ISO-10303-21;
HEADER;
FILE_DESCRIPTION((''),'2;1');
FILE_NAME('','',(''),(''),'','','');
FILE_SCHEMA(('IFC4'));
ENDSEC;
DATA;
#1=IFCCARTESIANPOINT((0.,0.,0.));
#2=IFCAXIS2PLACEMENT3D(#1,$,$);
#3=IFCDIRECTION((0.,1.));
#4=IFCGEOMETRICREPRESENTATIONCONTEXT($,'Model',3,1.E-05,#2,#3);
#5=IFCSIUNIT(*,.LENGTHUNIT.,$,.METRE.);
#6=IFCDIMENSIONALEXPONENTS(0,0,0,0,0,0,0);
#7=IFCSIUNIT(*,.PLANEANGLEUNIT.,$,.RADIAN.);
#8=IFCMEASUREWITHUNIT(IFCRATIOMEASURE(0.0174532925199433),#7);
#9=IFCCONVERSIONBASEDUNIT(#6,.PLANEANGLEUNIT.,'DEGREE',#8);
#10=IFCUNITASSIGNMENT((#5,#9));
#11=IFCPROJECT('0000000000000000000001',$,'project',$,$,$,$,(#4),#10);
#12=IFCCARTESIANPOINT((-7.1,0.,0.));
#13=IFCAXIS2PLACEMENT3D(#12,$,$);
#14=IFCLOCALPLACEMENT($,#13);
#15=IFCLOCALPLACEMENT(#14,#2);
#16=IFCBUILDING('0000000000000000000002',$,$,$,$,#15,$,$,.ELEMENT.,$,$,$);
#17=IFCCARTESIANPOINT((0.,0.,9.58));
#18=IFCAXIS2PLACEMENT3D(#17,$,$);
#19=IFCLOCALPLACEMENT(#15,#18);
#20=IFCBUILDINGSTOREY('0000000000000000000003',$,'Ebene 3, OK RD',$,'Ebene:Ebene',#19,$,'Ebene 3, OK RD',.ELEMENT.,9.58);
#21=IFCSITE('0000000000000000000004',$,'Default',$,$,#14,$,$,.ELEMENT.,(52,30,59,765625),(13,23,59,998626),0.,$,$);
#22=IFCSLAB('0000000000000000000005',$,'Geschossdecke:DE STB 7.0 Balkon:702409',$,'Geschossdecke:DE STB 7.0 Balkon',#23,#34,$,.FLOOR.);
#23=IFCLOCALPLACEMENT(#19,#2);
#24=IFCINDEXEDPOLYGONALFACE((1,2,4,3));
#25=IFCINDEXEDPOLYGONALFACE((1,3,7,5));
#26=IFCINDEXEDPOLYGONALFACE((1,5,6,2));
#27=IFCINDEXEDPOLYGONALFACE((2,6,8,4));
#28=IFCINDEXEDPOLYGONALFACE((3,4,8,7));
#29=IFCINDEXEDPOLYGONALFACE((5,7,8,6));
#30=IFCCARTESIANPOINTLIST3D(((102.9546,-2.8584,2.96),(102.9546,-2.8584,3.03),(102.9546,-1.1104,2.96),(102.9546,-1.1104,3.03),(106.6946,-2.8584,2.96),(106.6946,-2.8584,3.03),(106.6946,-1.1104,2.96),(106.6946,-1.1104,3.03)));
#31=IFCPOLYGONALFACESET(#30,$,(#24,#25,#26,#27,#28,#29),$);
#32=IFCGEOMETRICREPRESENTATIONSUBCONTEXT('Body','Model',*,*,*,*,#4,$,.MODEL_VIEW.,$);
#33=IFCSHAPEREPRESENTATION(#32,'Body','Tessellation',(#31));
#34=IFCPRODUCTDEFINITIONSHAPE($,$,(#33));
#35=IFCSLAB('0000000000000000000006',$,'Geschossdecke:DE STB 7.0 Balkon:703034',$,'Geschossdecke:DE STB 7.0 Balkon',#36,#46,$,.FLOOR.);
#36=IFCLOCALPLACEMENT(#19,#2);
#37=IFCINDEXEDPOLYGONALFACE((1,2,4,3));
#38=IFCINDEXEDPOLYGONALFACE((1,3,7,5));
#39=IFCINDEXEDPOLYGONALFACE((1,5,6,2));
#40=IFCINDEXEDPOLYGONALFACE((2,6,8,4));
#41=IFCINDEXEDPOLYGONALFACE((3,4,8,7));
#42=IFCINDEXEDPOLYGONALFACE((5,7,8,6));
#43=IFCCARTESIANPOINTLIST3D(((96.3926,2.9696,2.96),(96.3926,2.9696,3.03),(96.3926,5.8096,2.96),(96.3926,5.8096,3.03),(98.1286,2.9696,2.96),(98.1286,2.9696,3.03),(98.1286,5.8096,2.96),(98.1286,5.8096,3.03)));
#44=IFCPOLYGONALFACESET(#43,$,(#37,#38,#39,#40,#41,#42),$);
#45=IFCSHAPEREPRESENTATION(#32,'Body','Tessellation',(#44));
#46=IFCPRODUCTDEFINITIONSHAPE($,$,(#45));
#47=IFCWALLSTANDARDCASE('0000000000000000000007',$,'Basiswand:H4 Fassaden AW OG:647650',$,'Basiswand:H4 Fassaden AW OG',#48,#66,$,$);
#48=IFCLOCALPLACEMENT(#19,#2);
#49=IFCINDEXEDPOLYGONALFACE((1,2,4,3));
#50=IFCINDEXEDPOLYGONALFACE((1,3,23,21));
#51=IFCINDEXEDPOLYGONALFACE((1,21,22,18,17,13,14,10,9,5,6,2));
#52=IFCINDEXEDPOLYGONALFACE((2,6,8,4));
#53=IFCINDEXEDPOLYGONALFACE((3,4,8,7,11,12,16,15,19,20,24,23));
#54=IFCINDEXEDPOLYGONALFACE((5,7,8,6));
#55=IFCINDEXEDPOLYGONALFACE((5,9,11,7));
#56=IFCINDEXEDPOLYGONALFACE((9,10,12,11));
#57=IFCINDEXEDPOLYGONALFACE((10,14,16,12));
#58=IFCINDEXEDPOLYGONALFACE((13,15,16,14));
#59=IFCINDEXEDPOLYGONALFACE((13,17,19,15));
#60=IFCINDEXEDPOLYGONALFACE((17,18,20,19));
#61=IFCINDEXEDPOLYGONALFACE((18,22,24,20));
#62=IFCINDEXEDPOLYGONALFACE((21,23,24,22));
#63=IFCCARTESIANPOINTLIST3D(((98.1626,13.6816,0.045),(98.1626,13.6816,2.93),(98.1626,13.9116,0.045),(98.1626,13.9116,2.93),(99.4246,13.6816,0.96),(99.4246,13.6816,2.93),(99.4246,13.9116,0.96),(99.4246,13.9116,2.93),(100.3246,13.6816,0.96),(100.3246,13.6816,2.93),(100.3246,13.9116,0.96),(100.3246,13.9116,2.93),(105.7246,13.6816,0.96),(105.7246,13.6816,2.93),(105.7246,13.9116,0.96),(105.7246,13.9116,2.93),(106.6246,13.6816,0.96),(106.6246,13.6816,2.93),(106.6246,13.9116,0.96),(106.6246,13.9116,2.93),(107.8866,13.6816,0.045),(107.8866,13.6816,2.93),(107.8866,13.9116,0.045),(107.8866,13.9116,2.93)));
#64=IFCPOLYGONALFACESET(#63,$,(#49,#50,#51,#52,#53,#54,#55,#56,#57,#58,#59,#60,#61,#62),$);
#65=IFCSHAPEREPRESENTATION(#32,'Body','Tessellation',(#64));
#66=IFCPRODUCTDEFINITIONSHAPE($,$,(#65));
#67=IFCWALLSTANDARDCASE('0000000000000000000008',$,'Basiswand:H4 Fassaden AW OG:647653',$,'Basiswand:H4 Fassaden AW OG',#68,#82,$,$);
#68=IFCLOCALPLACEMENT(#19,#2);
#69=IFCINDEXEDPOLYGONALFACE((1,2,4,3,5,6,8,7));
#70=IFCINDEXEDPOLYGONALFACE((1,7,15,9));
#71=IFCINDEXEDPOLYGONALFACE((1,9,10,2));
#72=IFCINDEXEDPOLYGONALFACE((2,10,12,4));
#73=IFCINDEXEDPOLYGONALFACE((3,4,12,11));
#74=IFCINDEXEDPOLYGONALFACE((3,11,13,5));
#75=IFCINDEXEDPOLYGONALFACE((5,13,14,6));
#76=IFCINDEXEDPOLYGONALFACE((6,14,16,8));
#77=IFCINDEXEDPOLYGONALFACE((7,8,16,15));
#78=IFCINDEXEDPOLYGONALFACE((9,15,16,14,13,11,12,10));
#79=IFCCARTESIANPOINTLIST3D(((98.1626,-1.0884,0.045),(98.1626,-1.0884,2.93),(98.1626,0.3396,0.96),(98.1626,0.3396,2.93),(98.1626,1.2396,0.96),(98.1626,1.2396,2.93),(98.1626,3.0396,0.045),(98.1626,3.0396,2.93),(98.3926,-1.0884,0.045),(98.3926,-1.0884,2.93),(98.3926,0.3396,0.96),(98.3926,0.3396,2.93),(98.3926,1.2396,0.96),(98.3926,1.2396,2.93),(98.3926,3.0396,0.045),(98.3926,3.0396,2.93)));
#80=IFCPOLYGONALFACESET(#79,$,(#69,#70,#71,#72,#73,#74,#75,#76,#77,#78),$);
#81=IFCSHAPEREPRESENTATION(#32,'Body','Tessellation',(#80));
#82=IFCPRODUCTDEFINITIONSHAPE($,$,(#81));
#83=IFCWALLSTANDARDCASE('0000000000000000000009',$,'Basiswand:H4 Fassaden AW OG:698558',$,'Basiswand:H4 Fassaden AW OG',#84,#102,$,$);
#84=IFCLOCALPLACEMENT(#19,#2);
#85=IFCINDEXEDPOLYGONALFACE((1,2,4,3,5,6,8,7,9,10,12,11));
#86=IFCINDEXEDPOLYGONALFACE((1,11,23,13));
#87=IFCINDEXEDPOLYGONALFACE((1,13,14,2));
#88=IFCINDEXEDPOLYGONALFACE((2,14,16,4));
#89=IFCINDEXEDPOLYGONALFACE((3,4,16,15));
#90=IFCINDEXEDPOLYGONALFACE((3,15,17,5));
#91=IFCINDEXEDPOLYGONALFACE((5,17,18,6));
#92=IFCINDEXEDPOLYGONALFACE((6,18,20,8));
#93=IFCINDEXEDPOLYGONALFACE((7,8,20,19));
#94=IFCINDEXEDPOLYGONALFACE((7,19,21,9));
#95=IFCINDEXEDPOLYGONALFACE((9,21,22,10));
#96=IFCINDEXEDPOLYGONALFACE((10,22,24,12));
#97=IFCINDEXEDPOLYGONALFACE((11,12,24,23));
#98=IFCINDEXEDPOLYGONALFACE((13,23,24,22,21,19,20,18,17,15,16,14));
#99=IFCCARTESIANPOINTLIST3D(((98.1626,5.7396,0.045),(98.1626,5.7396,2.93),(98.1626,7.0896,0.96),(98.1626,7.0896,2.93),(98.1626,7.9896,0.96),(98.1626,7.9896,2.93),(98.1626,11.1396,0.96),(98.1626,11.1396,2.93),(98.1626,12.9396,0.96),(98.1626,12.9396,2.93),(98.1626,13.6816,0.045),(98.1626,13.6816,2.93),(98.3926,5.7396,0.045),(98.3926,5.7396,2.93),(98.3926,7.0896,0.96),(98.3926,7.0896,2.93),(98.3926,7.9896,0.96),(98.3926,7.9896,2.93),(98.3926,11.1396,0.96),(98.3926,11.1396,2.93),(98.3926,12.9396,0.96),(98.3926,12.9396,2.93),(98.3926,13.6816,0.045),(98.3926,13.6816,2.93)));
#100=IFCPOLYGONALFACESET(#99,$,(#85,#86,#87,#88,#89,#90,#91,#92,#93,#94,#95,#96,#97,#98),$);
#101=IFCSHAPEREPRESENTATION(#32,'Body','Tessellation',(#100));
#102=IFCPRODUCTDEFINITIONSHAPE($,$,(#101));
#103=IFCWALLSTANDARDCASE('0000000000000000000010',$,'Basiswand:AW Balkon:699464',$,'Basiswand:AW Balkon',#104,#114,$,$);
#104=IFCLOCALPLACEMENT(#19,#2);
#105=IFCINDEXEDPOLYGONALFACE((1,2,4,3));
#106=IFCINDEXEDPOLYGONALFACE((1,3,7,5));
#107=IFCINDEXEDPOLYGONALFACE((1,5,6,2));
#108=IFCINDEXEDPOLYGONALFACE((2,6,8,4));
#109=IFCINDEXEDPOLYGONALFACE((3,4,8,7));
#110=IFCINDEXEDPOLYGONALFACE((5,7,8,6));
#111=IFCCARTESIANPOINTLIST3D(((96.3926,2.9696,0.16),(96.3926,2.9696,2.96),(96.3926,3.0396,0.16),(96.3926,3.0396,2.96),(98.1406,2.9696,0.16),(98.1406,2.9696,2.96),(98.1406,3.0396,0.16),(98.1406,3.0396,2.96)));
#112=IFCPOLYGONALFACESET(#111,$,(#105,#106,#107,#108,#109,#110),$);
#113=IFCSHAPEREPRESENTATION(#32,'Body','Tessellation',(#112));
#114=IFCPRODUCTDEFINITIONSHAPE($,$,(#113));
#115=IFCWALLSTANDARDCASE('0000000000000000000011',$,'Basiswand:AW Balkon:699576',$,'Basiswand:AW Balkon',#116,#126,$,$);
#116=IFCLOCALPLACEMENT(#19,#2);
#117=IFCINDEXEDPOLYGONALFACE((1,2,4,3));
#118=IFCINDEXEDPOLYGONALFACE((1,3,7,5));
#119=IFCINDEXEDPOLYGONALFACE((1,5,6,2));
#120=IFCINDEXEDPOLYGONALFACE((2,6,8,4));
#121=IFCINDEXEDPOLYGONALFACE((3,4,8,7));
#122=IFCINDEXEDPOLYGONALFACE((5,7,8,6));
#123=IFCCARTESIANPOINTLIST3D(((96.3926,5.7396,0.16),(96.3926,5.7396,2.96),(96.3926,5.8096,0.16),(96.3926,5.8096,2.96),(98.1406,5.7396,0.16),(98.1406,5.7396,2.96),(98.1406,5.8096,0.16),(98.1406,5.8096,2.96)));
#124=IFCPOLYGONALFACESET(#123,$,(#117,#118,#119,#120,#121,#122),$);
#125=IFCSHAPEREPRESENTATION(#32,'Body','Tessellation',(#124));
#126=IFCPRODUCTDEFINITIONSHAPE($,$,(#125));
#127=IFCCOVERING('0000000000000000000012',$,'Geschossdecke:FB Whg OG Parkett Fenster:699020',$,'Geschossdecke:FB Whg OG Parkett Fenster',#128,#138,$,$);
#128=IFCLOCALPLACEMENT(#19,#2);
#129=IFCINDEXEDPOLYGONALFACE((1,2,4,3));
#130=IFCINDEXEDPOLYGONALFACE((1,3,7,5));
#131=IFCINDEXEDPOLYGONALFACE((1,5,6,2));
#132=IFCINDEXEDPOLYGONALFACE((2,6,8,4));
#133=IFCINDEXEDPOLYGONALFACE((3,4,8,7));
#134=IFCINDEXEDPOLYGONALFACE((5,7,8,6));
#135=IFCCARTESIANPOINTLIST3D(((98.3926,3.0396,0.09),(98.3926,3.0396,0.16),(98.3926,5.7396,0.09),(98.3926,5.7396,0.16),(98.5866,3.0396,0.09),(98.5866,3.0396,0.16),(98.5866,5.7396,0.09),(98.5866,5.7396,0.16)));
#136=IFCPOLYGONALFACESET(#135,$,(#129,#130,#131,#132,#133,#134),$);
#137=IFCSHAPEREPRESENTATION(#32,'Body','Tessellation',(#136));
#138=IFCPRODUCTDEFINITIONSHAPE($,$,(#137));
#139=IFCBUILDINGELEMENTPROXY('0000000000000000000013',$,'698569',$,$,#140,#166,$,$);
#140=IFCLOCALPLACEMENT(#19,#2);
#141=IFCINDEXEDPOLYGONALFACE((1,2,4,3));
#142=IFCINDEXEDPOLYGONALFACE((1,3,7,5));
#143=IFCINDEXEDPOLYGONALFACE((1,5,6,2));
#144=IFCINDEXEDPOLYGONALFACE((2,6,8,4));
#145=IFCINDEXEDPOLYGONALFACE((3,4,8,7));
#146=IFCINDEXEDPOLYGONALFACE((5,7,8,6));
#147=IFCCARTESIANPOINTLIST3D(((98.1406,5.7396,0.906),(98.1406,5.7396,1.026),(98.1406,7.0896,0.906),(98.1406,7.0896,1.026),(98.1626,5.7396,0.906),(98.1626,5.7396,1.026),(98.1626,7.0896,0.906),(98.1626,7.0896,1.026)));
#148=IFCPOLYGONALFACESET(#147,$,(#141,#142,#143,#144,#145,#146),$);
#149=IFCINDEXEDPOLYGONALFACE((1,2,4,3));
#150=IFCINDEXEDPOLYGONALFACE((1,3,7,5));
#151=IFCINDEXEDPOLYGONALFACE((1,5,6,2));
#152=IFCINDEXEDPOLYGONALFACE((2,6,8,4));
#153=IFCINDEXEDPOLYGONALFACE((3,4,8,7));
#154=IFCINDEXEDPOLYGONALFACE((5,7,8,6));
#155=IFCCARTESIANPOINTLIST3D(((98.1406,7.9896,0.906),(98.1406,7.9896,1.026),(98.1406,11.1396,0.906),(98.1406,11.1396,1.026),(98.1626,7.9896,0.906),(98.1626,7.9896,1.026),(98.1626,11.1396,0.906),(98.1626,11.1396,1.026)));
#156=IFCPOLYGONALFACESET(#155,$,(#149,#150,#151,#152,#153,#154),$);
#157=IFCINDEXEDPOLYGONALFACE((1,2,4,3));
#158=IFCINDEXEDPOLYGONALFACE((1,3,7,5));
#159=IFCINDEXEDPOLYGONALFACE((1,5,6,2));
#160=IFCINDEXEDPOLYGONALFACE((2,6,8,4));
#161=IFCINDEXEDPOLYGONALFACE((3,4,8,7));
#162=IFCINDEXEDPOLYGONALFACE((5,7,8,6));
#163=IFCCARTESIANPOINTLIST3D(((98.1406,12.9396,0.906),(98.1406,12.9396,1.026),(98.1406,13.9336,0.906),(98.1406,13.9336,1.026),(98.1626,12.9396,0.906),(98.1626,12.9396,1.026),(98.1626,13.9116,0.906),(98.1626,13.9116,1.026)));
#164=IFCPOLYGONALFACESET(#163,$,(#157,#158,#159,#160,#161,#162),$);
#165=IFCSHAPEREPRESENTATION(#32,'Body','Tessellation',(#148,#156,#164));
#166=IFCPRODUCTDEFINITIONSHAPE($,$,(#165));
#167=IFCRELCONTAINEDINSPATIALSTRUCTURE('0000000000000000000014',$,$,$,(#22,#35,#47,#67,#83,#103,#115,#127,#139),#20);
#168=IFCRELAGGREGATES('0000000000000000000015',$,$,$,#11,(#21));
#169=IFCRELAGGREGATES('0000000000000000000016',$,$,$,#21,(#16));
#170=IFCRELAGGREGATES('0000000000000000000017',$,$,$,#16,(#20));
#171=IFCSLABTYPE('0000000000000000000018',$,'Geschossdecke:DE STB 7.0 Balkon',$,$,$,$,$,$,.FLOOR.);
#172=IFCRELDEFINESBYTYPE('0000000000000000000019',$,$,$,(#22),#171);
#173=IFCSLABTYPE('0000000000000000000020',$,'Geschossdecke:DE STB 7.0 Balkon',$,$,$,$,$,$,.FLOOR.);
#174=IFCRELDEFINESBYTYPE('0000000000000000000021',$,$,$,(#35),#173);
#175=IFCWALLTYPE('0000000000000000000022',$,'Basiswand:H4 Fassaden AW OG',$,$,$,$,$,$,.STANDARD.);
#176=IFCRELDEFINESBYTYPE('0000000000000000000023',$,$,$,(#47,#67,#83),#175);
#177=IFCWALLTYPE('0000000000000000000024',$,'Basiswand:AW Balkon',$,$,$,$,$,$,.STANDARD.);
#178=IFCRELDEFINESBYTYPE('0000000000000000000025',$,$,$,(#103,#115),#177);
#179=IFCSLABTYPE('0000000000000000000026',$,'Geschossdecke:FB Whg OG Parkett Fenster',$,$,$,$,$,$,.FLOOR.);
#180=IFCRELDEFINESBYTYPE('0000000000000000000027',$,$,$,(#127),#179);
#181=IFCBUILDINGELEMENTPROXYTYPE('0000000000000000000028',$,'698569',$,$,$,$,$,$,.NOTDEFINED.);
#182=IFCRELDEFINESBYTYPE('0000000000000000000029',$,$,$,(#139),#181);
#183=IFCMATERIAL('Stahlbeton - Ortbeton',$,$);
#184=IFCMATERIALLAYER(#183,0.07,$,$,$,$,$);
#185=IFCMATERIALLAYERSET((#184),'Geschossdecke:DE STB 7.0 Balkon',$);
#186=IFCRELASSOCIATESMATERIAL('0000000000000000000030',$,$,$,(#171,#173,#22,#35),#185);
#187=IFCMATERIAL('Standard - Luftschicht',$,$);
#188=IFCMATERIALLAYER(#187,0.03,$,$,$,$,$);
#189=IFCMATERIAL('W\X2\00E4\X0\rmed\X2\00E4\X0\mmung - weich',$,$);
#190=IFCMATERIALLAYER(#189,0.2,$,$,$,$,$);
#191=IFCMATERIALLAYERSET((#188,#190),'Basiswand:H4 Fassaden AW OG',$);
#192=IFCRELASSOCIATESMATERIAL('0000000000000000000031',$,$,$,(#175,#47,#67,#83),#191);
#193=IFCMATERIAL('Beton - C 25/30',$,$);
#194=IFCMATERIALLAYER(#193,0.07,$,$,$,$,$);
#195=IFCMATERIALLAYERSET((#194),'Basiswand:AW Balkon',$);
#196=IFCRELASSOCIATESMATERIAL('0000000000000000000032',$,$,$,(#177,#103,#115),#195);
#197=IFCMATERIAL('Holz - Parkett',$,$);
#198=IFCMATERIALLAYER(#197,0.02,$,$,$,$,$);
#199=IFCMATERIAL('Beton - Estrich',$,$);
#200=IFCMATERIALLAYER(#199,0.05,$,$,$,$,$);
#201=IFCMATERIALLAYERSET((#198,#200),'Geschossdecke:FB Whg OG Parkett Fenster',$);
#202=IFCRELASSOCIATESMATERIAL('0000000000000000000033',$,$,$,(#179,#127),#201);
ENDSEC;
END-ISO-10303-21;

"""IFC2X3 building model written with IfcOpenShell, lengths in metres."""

from ifc_helpers import new_model, entity, si_unit, converted_unit, direction, frame, frame_2d, origin, origin_2d_with_axis, place, context, subcontext, project, spatial, polyline, rectangle, outline, extrude, material, layer, layer_set, layer_usage, type_object, element, save


model = new_model("IFC2X3")

# Units and contexts
model_context = context("Model", 3, precision=1e-05, world=origin(), true_north=direction((0.0, 1.0)))
body_context = subcontext(model_context, "Body", "Model", "MODEL_VIEW")
ifc_project = project(units=[si_unit("LENGTHUNIT", "METRE"), converted_unit("PLANEANGLEUNIT", "DEGREE", entity("IfcRatioMeasure", 0.0174532925199433), si_unit("PLANEANGLEUNIT", "RADIAN"), dimensions=[0, 0, 0, 0, 0, 0, 0])], contexts=[model_context])

# Site, building, storey
site_placement = place(None, frame((-7.1, 0.0, 0.0)))
site = spatial("IfcSite", under=ifc_project, at=site_placement, Name="Default", CompositionType="ELEMENT", RefLatitude=(52, 30, 59, 765625), RefLongitude=(13, 23, 59, 998626), RefElevation=0.0)
building_placement = place(site_placement, origin())
building = spatial("IfcBuilding", under=site, at=building_placement, CompositionType="ELEMENT")
storey_placement = place(building_placement, frame((0.0, 0.0, 9.58)))
storey = spatial("IfcBuildingStorey", under=building, at=storey_placement, Name="Ebene 3, OK RD", ObjectType="Ebene:Ebene", LongName="Ebene 3, OK RD", CompositionType="ELEMENT", Elevation=9.58)

# Slabs
ifc_material_1 = material(Name="Stahlbeton - Ortbeton")
ifc_layer_1 = layer(ifc_material_1, 0.07)
ifc_layer_set_1 = layer_set([ifc_layer_1], Name="Geschossdecke:DE STB 7.0 Balkon")
ifc_layer_usage_1 = layer_usage(ifc_layer_set_1, "AXIS3", "POSITIVE", 0.0)
slab_type_1 = type_object("IfcSlabType", Name="Geschossdecke:DE STB 7.0 Balkon", PredefinedType="FLOOR", material=ifc_layer_set_1)
slab_1_placement = place(storey_placement, origin())
element("IfcSlab", 1, at=slab_1_placement, inside=storey, type_object=slab_type_1, material=ifc_layer_usage_1, Name="Geschossdecke:DE STB 7.0 Balkon:702409", ObjectType="Geschossdecke:DE STB 7.0 Balkon", PredefinedType="FLOOR", context=body_context, shape_type="SweptSolid", body=[
    extrude(rectangle(XDim=1.748, YDim=3.74, at=frame_2d((0.0, 0.0), x_axis=(1.0, 0.0))), frame((104.8246, -1.9844, 3.03), z_axis=(0.0, 0.0, -1.0), x_axis=(0.0, 1.0, 0.0)), (0.0, 0.0, 1.0), 0.07),
])
ifc_layer_usage_2 = layer_usage(ifc_layer_set_1, "AXIS3", "POSITIVE", 0.0)
slab_type_2 = type_object("IfcSlabType", Name="Geschossdecke:DE STB 7.0 Balkon", PredefinedType="FLOOR", material=ifc_layer_set_1)
slab_2_placement = place(storey_placement, origin())
element("IfcSlab", 2, at=slab_2_placement, inside=storey, type_object=slab_type_2, material=ifc_layer_usage_2, Name="Geschossdecke:DE STB 7.0 Balkon:703034", ObjectType="Geschossdecke:DE STB 7.0 Balkon", PredefinedType="FLOOR", context=body_context, shape_type="SweptSolid", body=[
    extrude(rectangle(XDim=2.84, YDim=1.736, at=origin_2d_with_axis()), frame((97.2606, 4.3896, 3.03), z_axis=(0.0, 0.0, -1.0), x_axis=(0.0, 1.0, 0.0)), (0.0, 0.0, 1.0), 0.07),
])

# Shared definitions
ifc_material_2 = material(Name="Standard - Luftschicht")
ifc_material_3 = material(Name="Wärmedämmung - weich")

# Wall, openings
ifc_layer_2 = layer(ifc_material_2, 0.03)
ifc_layer_3 = layer(ifc_material_3, 0.2)
ifc_layer_set_2 = layer_set([ifc_layer_2, ifc_layer_3], Name="Basiswand:H4 Fassaden AW OG")
ifc_layer_usage_3 = layer_usage(ifc_layer_set_2, "AXIS2", "NEGATIVE", 0.115)
wall_type_1 = type_object("IfcWallType", Name="Basiswand:H4 Fassaden AW OG", PredefinedType="STANDARD", material=ifc_layer_set_2)
wall_1_placement = place(storey_placement, frame((98.1626, 13.7966, 0.045)))
wall_1 = element("IfcWallStandardCase", 3, at=wall_1_placement, inside=storey, type_object=wall_type_1, material=ifc_layer_usage_3, Name="Basiswand:H4 Fassaden AW OG:647650", ObjectType="Basiswand:H4 Fassaden AW OG", context=body_context, shape_type="SweptSolid", body=[
    extrude(rectangle(XDim=9.724, YDim=0.23, at=frame_2d((4.862, 0.0), x_axis=(-1.0, 0.0))), origin(), (0.0, 0.0, 1.0), 2.885),
])
opening_1_placement = place(wall_1_placement, frame((8.462, 0.115, 0.915)))
element("IfcOpeningElement", 4, at=opening_1_placement, cuts=wall_1, ObjectType="Opening", context=body_context, shape_type="SweptSolid", body=[
    extrude(rectangle(XDim=1.97, YDim=0.9, at=frame_2d((0.985, 0.45), x_axis=(1.0, 0.0))), frame((0.0, 0.0, 0.0), z_axis=(0.0, -1.0, 0.0), x_axis=(0.0, 0.0, 1.0)), (0.0, 0.0, 1.0), 0.23),
])
opening_2_placement = place(wall_1_placement, frame((2.162, 0.115, 0.915)))
element("IfcOpeningElement", 5, at=opening_2_placement, cuts=wall_1, ObjectType="Opening", context=body_context, shape_type="SweptSolid", body=[
    extrude(rectangle(XDim=1.97, YDim=0.9, at=frame_2d((0.985, 0.45), x_axis=(1.0, 0.0))), frame((0.0, 0.0, 0.0), z_axis=(0.0, -1.0, 0.0), x_axis=(0.0, 0.0, 1.0)), (0.0, 0.0, 1.0), 0.23),
])

# Wall, opening
ifc_layer_usage_4 = layer_usage(ifc_layer_set_2, "AXIS2", "NEGATIVE", 0.115)
wall_2_placement = place(storey_placement, frame((98.2776, -1.0884, 0.045), z_axis=(0.0, 0.0, 1.0), x_axis=(0.0, 1.0, 0.0)))
wall_2 = element("IfcWallStandardCase", 6, at=wall_2_placement, inside=storey, type_object=wall_type_1, material=ifc_layer_usage_4, Name="Basiswand:H4 Fassaden AW OG:647653", ObjectType="Basiswand:H4 Fassaden AW OG", context=body_context, shape_type="SweptSolid", body=[
    extrude(rectangle(XDim=4.128, YDim=0.23, at=frame_2d((2.064, 0.0), x_axis=(-1.0, 0.0))), origin(), (0.0, 0.0, 1.0), 2.885),
])
opening_3_placement = place(wall_2_placement, frame((2.328, 0.115, 0.915)))
element("IfcOpeningElement", 7, at=opening_3_placement, cuts=wall_2, ObjectType="Opening", context=body_context, shape_type="SweptSolid", body=[
    extrude(rectangle(XDim=1.97, YDim=0.9, at=frame_2d((0.985, 0.45), x_axis=(1.0, 0.0))), frame((0.0, 0.0, 0.0), z_axis=(0.0, -1.0, 0.0), x_axis=(0.0, 0.0, 1.0)), (0.0, 0.0, 1.0), 0.23),
])

# Wall, openings
ifc_layer_usage_5 = layer_usage(ifc_layer_set_2, "AXIS2", "NEGATIVE", 0.115)
wall_3_placement = place(storey_placement, frame((98.2776, 5.7396, 0.045), z_axis=(0.0, 0.0, 1.0), x_axis=(0.0, 1.0, 0.0)))
wall_3 = element("IfcWallStandardCase", 8, at=wall_3_placement, inside=storey, type_object=wall_type_1, material=ifc_layer_usage_5, Name="Basiswand:H4 Fassaden AW OG:698558", ObjectType="Basiswand:H4 Fassaden AW OG", context=body_context, shape_type="SweptSolid", body=[
    extrude(rectangle(XDim=7.942, YDim=0.23, at=frame_2d((3.971, 0.0), x_axis=(-1.0, 0.0))), origin(), (0.0, 0.0, 1.0), 2.885),
])
opening_4_placement = place(wall_3_placement, frame((7.2, 0.115, 0.915)))
element("IfcOpeningElement", 9, at=opening_4_placement, cuts=wall_3, ObjectType="Opening", context=body_context, shape_type="SweptSolid", body=[
    extrude(rectangle(XDim=1.97, YDim=1.8, at=frame_2d((0.985, 0.9), x_axis=(1.0, 0.0))), frame((0.0, 0.0, 0.0), z_axis=(0.0, -1.0, 0.0), x_axis=(0.0, 0.0, 1.0)), (0.0, 0.0, 1.0), 0.23),
])
opening_5_placement = place(wall_3_placement, frame((2.25, 0.115, 0.915)))
element("IfcOpeningElement", 10, at=opening_5_placement, cuts=wall_3, ObjectType="Opening", context=body_context, shape_type="SweptSolid", body=[
    extrude(rectangle(XDim=1.97, YDim=0.9, at=frame_2d((0.985, 0.45), x_axis=(1.0, 0.0))), frame((0.0, 0.0, 0.0), z_axis=(0.0, -1.0, 0.0), x_axis=(0.0, 0.0, 1.0)), (0.0, 0.0, 1.0), 0.23),
])

# Walls
ifc_material_4 = material(Name="Beton - C 25/30")
ifc_layer_4 = layer(ifc_material_4, 0.07)
ifc_layer_set_3 = layer_set([ifc_layer_4], Name="Basiswand:AW Balkon")
ifc_layer_usage_6 = layer_usage(ifc_layer_set_3, "AXIS2", "NEGATIVE", 0.035)
wall_type_2 = type_object("IfcWallType", Name="Basiswand:AW Balkon", PredefinedType="STANDARD", material=ifc_layer_set_3)
wall_4_placement = place(storey_placement, frame((98.1406, 3.0046, 0.16), z_axis=(0.0, 0.0, 1.0), x_axis=(-1.0, 0.0, 0.0)))
element("IfcWallStandardCase", 11, at=wall_4_placement, inside=storey, type_object=wall_type_2, material=ifc_layer_usage_6, Name="Basiswand:AW Balkon:699464", ObjectType="Basiswand:AW Balkon", context=body_context, shape_type="SweptSolid", body=[
    extrude(rectangle(XDim=1.748, YDim=0.07, at=frame_2d((0.874, 0.0), x_axis=(-1.0, 0.0))), origin(), (0.0, 0.0, 1.0), 2.8),
])
ifc_layer_usage_7 = layer_usage(ifc_layer_set_3, "AXIS2", "NEGATIVE", 0.035)
wall_5_placement = place(storey_placement, frame((96.3926, 5.7746, 0.16)))
element("IfcWallStandardCase", 12, at=wall_5_placement, inside=storey, type_object=wall_type_2, material=ifc_layer_usage_7, Name="Basiswand:AW Balkon:699576", ObjectType="Basiswand:AW Balkon", context=body_context, shape_type="SweptSolid", body=[
    extrude(rectangle(XDim=1.748, YDim=0.07, at=frame_2d((0.874, 0.0), x_axis=(-1.0, 0.0))), origin(), (0.0, 0.0, 1.0), 2.8),
])

# Covering
ifc_material_5 = material(Name="Holz - Parkett")
ifc_layer_5 = layer(ifc_material_5, 0.02)
ifc_material_6 = material(Name="Beton - Estrich")
ifc_layer_6 = layer(ifc_material_6, 0.05)
ifc_layer_set_4 = layer_set([ifc_layer_5, ifc_layer_6], Name="Geschossdecke:FB Whg OG Parkett Fenster")
ifc_layer_usage_8 = layer_usage(ifc_layer_set_4, "AXIS3", "POSITIVE", 0.0)
slab_type_3 = type_object("IfcSlabType", Name="Geschossdecke:FB Whg OG Parkett Fenster", PredefinedType="FLOOR", material=ifc_layer_set_4)
covering_placement = place(storey_placement, origin())
element("IfcCovering", 13, at=covering_placement, inside=storey, type_object=slab_type_3, material=ifc_layer_usage_8, Name="Geschossdecke:FB Whg OG Parkett Fenster:699020", ObjectType="Geschossdecke:FB Whg OG Parkett Fenster", context=body_context, shape_type="SweptSolid", body=[
    extrude(rectangle(XDim=2.7, YDim=0.194, at=frame_2d((0.0, 0.0), x_axis=(1.0, 0.0))), frame((98.4896, 4.3896, 0.16), z_axis=(0.0, 0.0, -1.0), x_axis=(0.0, 1.0, 0.0)), (0.0, 0.0, 1.0), 0.07),
])

# Building element proxy
building_element_proxy_type_1 = type_object("IfcBuildingElementProxyType", Name="698569", PredefinedType="NOTDEFINED")
proxy_1_placement = place(storey_placement, origin())
element("IfcBuildingElementProxy", 14, at=proxy_1_placement, inside=storey, type_object=building_element_proxy_type_1, Name="698569", context=body_context, shape_type="SweptSolid", body=[
    extrude(rectangle(XDim=1.35, YDim=0.022, at=frame_2d((0.0, 0.0), x_axis=(1.0, 0.0))), frame((98.1516, 6.4146, 0.906), z_axis=(0.0, 0.0, 1.0), x_axis=(0.0, 1.0, 0.0)), (0.0, 0.0, 1.0), 0.12),
    extrude(rectangle(XDim=3.15, YDim=0.022, at=frame_2d((0.0, 0.0), x_axis=(1.0, 0.0))), frame((98.1516, 9.5646, 0.906), z_axis=(0.0, 0.0, 1.0), x_axis=(0.0, 1.0, 0.0)), (0.0, 0.0, 1.0), 0.12),
    extrude(outline(polyline([(-0.4915, -0.011), (0.4805, -0.011), (0.5025, 0.011), (-0.4915, 0.011), (-0.4915, -0.011)])), frame((98.1516, 13.4311, 0.906), z_axis=(0.0, 0.0, 1.0), x_axis=(0.0, 1.0, 0.0)), (0.0, 0.0, 1.0), 0.12),
])

save(model, "model.ifc")
